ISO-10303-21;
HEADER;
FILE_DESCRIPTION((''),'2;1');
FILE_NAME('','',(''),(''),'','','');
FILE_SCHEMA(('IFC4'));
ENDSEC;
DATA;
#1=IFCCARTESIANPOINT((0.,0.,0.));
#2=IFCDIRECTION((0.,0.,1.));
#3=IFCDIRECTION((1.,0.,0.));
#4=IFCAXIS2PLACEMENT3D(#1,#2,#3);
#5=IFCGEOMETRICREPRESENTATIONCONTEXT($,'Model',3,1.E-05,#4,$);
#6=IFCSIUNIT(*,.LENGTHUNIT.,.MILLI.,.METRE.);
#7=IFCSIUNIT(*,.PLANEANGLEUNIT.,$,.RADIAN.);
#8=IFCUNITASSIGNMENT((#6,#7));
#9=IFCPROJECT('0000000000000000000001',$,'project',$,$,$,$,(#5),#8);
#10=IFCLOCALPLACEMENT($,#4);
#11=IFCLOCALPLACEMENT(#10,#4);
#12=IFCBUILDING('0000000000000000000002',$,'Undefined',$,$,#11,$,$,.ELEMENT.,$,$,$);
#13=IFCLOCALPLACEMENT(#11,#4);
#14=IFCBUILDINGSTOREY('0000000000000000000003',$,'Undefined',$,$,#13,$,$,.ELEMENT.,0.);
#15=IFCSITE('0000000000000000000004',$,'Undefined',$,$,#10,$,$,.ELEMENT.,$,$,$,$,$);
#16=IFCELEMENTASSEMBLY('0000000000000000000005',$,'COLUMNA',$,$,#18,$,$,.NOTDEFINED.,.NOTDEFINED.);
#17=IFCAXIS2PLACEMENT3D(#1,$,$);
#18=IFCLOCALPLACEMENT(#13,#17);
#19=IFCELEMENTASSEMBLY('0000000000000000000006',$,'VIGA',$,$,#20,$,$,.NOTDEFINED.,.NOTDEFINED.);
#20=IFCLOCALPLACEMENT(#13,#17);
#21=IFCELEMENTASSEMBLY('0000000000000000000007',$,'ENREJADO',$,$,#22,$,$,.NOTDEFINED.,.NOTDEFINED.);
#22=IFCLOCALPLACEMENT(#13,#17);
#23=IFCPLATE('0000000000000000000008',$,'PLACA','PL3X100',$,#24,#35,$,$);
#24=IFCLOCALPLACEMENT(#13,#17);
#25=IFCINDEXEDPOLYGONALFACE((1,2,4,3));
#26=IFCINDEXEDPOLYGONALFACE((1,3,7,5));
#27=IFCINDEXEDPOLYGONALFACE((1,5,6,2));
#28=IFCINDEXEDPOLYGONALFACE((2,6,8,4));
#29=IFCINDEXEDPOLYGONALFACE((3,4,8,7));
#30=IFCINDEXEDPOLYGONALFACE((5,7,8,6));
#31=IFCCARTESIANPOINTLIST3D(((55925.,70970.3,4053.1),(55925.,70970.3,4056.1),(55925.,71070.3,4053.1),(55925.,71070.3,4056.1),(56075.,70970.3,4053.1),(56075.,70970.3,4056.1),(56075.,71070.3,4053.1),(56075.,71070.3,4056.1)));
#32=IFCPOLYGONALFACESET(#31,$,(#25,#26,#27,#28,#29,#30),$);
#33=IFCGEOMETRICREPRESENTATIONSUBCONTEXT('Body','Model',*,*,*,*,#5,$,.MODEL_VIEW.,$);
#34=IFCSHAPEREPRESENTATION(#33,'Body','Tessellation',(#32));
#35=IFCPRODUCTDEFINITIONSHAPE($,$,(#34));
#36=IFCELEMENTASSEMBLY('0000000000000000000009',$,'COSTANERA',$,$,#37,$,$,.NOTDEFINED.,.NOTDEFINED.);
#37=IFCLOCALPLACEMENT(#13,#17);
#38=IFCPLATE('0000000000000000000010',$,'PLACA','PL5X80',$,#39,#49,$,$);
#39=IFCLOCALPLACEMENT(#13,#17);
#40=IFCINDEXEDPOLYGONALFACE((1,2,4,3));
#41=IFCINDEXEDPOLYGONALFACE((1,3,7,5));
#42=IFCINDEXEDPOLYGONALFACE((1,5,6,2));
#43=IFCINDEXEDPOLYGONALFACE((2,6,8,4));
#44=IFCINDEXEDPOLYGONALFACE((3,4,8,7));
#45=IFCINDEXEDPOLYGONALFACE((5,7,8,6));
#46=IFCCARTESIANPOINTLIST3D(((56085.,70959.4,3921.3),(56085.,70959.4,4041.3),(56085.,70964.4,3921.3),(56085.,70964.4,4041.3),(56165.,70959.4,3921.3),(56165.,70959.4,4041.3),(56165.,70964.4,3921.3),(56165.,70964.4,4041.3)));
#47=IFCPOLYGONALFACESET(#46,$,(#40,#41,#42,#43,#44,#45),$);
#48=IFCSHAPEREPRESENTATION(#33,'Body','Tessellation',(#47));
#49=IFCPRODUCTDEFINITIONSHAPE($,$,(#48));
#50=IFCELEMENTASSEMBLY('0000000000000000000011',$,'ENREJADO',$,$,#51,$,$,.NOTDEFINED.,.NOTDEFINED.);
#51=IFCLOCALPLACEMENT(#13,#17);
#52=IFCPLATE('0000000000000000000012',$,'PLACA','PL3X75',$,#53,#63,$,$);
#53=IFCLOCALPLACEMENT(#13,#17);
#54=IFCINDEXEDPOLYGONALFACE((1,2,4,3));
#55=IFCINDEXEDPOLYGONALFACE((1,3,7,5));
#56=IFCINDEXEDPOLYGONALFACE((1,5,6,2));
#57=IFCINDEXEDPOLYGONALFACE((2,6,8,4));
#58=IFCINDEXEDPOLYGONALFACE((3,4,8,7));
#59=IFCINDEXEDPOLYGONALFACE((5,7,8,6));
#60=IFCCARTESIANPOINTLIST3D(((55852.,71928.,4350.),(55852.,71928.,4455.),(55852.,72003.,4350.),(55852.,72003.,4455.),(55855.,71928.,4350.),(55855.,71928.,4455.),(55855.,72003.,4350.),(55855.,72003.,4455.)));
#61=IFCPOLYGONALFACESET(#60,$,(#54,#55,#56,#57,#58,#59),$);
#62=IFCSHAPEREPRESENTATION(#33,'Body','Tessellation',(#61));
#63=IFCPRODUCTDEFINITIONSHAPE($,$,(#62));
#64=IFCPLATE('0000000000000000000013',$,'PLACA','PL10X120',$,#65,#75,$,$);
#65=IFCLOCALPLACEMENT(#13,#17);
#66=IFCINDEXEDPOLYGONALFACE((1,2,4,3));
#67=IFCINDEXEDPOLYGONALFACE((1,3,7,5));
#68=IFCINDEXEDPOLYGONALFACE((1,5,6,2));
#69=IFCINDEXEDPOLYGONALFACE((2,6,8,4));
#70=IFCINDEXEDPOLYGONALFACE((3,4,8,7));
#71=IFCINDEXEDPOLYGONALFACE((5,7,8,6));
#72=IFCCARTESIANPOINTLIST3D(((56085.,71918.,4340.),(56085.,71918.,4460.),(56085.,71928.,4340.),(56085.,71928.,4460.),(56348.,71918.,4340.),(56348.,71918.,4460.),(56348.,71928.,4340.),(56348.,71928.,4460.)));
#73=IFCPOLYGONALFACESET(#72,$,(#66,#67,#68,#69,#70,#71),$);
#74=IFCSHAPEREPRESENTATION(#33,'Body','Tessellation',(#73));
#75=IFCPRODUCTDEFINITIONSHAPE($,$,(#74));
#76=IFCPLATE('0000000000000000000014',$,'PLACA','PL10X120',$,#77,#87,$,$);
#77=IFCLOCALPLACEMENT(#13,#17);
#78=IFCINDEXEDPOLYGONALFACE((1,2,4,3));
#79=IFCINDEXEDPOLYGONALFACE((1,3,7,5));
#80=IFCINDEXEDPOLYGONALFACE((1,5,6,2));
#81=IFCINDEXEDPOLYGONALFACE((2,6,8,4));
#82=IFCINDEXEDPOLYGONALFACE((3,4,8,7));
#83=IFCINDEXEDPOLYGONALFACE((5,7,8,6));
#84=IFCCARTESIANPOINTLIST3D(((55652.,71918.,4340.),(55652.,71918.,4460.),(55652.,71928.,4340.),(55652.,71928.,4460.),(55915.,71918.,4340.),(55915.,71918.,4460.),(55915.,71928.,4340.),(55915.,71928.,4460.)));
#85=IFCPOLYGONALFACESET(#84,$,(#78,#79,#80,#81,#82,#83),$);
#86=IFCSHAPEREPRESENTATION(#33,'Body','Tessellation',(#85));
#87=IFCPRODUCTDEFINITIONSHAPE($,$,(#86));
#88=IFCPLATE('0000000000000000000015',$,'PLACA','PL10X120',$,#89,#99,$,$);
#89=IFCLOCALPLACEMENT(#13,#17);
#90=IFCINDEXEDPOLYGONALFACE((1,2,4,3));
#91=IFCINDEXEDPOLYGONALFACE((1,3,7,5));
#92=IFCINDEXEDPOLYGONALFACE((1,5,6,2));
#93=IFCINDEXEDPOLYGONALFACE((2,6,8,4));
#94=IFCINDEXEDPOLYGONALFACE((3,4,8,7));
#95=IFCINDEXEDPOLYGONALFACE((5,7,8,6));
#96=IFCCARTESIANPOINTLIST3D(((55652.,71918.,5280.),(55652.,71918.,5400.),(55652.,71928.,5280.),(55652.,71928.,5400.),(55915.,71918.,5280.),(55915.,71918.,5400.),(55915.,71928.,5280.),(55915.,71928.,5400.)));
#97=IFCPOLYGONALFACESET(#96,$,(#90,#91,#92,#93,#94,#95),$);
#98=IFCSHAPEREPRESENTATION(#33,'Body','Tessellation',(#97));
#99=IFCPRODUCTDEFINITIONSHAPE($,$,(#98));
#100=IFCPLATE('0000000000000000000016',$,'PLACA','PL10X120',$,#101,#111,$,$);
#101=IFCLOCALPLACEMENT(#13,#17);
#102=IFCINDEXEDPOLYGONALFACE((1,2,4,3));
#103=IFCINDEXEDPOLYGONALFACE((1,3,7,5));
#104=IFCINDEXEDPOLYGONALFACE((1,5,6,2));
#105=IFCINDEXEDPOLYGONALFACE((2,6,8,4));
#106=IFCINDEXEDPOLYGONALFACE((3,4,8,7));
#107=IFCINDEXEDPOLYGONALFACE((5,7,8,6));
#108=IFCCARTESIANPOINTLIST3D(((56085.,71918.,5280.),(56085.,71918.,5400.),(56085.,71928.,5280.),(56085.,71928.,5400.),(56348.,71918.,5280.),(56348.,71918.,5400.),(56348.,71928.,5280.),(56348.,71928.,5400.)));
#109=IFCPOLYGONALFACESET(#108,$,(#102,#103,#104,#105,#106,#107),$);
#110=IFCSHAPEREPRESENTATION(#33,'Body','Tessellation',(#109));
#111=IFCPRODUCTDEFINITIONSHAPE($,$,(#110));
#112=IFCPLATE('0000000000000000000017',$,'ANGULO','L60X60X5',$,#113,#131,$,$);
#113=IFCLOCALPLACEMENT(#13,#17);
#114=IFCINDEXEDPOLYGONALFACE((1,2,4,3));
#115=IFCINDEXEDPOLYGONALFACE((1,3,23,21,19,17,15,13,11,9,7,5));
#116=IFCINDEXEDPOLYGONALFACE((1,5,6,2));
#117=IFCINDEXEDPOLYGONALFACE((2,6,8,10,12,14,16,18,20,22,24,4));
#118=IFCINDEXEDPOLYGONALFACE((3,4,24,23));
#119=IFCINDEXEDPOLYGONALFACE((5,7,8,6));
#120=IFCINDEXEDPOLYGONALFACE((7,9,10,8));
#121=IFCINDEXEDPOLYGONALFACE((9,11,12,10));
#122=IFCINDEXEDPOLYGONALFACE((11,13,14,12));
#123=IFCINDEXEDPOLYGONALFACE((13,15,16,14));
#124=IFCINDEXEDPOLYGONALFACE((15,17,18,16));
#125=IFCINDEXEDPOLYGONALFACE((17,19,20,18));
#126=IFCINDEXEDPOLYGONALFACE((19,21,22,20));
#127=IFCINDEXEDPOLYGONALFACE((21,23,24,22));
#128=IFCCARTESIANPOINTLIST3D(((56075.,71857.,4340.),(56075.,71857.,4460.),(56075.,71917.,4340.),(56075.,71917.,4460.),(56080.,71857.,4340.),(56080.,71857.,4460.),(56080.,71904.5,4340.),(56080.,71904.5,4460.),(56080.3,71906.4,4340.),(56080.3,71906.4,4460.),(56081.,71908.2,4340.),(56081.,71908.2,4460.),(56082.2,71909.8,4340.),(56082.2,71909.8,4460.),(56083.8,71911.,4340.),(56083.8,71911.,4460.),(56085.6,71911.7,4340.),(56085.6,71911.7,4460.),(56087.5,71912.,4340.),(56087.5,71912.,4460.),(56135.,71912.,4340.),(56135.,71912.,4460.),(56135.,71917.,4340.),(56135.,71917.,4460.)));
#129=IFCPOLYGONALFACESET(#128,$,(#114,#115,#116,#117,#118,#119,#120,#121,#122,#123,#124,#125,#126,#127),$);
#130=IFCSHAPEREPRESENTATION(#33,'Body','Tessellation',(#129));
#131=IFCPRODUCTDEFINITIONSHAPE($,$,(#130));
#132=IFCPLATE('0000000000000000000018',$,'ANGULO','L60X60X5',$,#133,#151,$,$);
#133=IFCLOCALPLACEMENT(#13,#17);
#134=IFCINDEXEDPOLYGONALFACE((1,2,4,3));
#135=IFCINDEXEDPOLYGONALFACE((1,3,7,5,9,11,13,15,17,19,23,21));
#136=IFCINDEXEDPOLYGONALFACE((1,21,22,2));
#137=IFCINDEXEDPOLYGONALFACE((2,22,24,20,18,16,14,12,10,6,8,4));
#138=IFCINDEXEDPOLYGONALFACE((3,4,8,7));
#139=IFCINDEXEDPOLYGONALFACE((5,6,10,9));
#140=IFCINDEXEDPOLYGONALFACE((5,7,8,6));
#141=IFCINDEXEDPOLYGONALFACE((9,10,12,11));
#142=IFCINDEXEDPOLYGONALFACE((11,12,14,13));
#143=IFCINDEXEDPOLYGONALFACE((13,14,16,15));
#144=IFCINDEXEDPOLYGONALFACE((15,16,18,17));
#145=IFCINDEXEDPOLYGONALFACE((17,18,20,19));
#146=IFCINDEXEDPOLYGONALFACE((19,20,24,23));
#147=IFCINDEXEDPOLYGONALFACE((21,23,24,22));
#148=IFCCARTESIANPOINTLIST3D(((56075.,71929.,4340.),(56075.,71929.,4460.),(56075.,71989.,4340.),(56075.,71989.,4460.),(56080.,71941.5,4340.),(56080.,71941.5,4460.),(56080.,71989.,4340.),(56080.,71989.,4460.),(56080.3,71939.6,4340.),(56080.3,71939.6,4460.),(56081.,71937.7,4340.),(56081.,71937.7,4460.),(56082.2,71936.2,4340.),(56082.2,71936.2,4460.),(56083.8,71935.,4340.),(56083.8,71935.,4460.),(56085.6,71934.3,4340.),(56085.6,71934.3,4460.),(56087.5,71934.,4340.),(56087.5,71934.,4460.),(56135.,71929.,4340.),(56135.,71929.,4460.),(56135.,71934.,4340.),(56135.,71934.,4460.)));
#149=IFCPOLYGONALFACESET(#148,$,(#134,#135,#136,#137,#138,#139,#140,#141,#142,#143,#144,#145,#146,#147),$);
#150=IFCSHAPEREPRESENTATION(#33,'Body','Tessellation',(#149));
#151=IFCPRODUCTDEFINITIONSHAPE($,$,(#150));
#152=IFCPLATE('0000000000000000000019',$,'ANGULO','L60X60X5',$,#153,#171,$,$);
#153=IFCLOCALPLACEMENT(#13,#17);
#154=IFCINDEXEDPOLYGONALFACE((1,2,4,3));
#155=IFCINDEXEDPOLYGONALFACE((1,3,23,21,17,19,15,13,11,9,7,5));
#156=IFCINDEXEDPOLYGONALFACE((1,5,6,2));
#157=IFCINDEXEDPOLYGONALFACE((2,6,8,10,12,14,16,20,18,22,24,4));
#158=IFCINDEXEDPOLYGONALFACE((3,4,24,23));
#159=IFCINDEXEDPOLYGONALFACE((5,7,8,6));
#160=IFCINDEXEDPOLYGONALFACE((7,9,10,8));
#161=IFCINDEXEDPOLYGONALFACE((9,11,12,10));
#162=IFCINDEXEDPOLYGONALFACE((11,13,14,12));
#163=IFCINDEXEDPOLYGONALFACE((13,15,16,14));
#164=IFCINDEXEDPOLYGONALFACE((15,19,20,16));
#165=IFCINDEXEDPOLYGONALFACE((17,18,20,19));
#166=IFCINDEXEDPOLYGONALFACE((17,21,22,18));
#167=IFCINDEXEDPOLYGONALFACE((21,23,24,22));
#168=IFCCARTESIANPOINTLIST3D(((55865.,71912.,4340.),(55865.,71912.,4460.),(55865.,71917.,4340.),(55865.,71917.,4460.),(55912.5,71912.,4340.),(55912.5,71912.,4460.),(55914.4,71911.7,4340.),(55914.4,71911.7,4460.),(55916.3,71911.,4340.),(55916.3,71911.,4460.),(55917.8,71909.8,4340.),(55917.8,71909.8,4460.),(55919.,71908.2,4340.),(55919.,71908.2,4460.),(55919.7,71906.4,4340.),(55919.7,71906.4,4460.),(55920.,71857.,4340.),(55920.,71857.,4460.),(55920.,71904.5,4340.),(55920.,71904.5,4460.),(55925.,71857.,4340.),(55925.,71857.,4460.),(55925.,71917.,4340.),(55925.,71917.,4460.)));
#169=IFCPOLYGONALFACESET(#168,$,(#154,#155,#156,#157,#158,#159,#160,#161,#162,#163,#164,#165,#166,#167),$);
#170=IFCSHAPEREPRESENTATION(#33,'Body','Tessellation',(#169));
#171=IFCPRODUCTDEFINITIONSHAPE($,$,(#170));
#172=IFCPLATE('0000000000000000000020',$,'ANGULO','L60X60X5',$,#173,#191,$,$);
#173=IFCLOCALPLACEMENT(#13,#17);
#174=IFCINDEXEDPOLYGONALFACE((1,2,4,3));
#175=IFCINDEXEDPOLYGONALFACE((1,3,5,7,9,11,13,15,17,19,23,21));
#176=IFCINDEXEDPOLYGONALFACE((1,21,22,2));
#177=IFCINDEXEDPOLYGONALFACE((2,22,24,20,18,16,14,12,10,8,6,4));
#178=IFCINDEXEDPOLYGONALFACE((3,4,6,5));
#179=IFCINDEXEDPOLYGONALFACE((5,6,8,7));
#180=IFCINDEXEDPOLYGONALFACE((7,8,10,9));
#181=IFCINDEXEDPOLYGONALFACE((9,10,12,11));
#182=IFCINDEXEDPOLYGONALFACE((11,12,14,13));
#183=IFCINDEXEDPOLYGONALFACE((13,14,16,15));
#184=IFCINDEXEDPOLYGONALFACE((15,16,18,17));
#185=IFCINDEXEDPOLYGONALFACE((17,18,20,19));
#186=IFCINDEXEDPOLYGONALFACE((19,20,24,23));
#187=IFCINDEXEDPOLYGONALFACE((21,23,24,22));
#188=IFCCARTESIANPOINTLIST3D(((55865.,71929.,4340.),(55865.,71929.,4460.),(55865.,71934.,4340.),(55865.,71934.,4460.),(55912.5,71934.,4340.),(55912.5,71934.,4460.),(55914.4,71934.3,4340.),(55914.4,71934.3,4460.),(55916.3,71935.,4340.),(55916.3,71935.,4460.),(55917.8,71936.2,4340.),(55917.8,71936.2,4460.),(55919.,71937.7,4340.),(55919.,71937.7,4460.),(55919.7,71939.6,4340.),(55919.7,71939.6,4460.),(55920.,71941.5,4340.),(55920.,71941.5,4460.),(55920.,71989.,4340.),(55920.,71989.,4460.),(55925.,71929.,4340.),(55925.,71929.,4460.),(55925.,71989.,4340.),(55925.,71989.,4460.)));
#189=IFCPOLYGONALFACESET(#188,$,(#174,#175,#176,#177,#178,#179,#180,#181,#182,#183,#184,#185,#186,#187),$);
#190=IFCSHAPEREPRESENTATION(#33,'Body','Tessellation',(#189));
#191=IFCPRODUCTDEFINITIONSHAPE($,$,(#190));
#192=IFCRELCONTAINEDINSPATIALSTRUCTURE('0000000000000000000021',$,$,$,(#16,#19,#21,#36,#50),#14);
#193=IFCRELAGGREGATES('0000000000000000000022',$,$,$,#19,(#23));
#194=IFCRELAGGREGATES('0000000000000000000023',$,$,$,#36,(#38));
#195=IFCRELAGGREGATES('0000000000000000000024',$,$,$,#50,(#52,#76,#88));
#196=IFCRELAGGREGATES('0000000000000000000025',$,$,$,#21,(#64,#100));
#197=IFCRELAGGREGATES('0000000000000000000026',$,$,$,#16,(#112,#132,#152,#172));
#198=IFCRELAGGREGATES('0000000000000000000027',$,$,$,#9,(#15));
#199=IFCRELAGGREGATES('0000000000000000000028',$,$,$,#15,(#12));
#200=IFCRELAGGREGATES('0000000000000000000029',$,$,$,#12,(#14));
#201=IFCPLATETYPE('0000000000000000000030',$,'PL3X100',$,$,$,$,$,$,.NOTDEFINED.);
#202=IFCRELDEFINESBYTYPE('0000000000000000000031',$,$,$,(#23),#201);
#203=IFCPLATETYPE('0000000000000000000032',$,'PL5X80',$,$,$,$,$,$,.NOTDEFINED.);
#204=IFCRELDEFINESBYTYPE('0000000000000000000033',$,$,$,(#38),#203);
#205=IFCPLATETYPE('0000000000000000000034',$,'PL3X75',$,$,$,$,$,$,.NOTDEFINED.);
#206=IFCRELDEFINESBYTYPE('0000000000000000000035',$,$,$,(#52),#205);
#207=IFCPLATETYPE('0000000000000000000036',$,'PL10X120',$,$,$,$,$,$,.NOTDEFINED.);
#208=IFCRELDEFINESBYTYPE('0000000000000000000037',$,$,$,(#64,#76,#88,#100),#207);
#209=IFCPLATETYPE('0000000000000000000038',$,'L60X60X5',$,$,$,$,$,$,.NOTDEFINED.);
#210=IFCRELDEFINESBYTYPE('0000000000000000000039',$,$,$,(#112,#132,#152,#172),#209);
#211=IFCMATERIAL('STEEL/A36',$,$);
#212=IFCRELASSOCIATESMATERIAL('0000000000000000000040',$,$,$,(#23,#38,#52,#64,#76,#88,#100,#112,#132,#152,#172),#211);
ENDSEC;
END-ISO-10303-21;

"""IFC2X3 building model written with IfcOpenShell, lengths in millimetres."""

from ifc_helpers import new_model, si_unit, frame, origin_with_axes, origin_2d_with_axis, place, context, subcontext, project, spatial, polyline, l_section, outline, extrude, material, type_object, element, aggregate, save


model = new_model("IFC2X3")

# Units and contexts
model_context = context("Model", 3, precision=1e-05, world=origin_with_axes())
body_context = subcontext(model_context, "Body", "Model", "MODEL_VIEW")
ifc_project = project(units=[si_unit("LENGTHUNIT", "METRE", prefix="MILLI"), si_unit("PLANEANGLEUNIT", "RADIAN")], contexts=[model_context])

# Site, building, storey
site_placement = place(None, origin_with_axes())
site = spatial("IfcSite", under=ifc_project, at=site_placement, Name="Undefined", CompositionType="ELEMENT")
building_placement = place(site_placement, origin_with_axes())
building = spatial("IfcBuilding", under=site, at=building_placement, Name="Undefined", CompositionType="ELEMENT")
storey_placement = place(building_placement, origin_with_axes())
storey = spatial("IfcBuildingStorey", under=building, at=storey_placement, Name="Undefined", CompositionType="ELEMENT", Elevation=0.0)

# Element assembly
assembly_1_placement = place(storey_placement, origin_with_axes())
assembly_1 = element("IfcElementAssembly", 1, at=assembly_1_placement, inside=storey, Name="COLUMNA", AssemblyPlace="NOTDEFINED", PredefinedType="NOTDEFINED")
ifc_material_1 = material(Name="STEEL/A36")

# Element assemblies
assembly_2_placement = place(storey_placement, origin_with_axes())
assembly_2 = element("IfcElementAssembly", 2, at=assembly_2_placement, inside=storey, Name="VIGA", AssemblyPlace="NOTDEFINED", PredefinedType="NOTDEFINED")
assembly_3_placement = place(storey_placement, origin_with_axes())
assembly_3 = element("IfcElementAssembly", 3, at=assembly_3_placement, inside=storey, Name="ENREJADO", AssemblyPlace="NOTDEFINED", PredefinedType="NOTDEFINED")

# Plate
plate_type_1 = type_object("IfcPlateType", Name="PL3X100", PredefinedType="NOTDEFINED")
plate_1_placement = place(assembly_2_placement, frame((56075.0, 71070.3, 4054.6), z_axis=(0.0, 0.0, -1.0), x_axis=(0.0, -1.0, 0.0)))
plate_1 = element("IfcPlate", 4, at=plate_1_placement, type_object=plate_type_1, material=ifc_material_1, Name="PLACA", Description="PL3X100", context=body_context, shape_type="SweptSolid", body=[
    extrude(outline(polyline([(0.0, 0.0), (100.0, 0.0), (100.0, 150.0), (0.0, 150.0), (0.0, 0.0)])), frame((0.0, 0.0, -1.5), z_axis=(0.0, 0.0, 1.0), x_axis=(1.0, 0.0, 0.0)), (0.0, 0.0, 1.0), 3.0),
])
aggregate(assembly_2, [plate_1])

# Element assemblies, plates
assembly_4_placement = place(storey_placement, origin_with_axes())
assembly_4 = element("IfcElementAssembly", 5, at=assembly_4_placement, inside=storey, Name="COSTANERA", AssemblyPlace="NOTDEFINED", PredefinedType="NOTDEFINED")
plate_type_2 = type_object("IfcPlateType", Name="PL5X80", PredefinedType="NOTDEFINED")
plate_2_placement = place(assembly_4_placement, frame((56085.0, 70961.9, 4041.3), z_axis=(0.0, 1.0, 0.0), x_axis=(1.0, 0.0, 0.0)))
plate_2 = element("IfcPlate", 6, at=plate_2_placement, type_object=plate_type_2, material=ifc_material_1, Name="PLACA", Description="PL5X80", context=body_context, shape_type="SweptSolid", body=[
    extrude(outline(polyline([(0.0, 0.0), (80.0, 0.0), (80.0, 120.0), (0.0, 120.0), (0.0, 0.0)])), frame((0.0, 0.0, -2.5), z_axis=(0.0, 0.0, 1.0), x_axis=(1.0, 0.0, 0.0)), (0.0, 0.0, 1.0), 5.0),
])
aggregate(assembly_4, [plate_2])
assembly_5_placement = place(storey_placement, origin_with_axes())
assembly_5 = element("IfcElementAssembly", 7, at=assembly_5_placement, inside=storey, Name="ENREJADO", AssemblyPlace="NOTDEFINED", PredefinedType="NOTDEFINED")
plate_type_3 = type_object("IfcPlateType", Name="PL3X75", PredefinedType="NOTDEFINED")
plate_3_placement = place(assembly_5_placement, frame((55853.5, 71928.0, 4455.0), z_axis=(-1.0, 0.0, 0.0), x_axis=(0.0, 1.0, 0.0)))
plate_3 = element("IfcPlate", 8, at=plate_3_placement, type_object=plate_type_3, material=ifc_material_1, Name="PLACA", Description="PL3X75", context=body_context, shape_type="SweptSolid", body=[
    extrude(outline(polyline([(0.0, 0.0), (75.0, 0.0), (75.0, 105.0), (0.0, 105.0), (0.0, 0.0)])), frame((0.0, 0.0, -1.5), z_axis=(0.0, 0.0, 1.0), x_axis=(1.0, 0.0, 0.0)), (0.0, 0.0, 1.0), 3.0),
])

# Plates
plate_type_4 = type_object("IfcPlateType", Name="PL10X120", PredefinedType="NOTDEFINED")
plate_4_placement = place(assembly_3_placement, frame((56085.0, 71923.0, 4400.0), z_axis=(0.0, 1.0, 0.0), x_axis=(1.0, 0.0, 0.0)))
plate_4 = element("IfcPlate", 9, at=plate_4_placement, type_object=plate_type_4, material=ifc_material_1, Name="PLACA", Description="PL10X120", context=body_context, shape_type="SweptSolid", body=[
    extrude(outline(polyline([(0.0, -60.0), (0.0, 60.0), (263.0, 60.0), (263.0, -60.0), (0.0, -60.0)])), frame((0.0, 0.0, -5.0), z_axis=(0.0, 0.0, 1.0), x_axis=(1.0, 0.0, 0.0)), (0.0, 0.0, 1.0), 10.0),
])
plate_5_placement = place(assembly_5_placement, frame((55915.0, 71923.0, 4400.0), z_axis=(0.0, 1.0, 0.0), x_axis=(-1.0, 0.0, 0.0)))
plate_5 = element("IfcPlate", 10, at=plate_5_placement, type_object=plate_type_4, material=ifc_material_1, Name="PLACA", Description="PL10X120", context=body_context, shape_type="SweptSolid", body=[
    extrude(outline(polyline([(0.0, -60.0), (0.0, 60.0), (263.0, 60.0), (263.0, -60.0), (0.0, -60.0)])), frame((0.0, 0.0, -5.0), z_axis=(0.0, 0.0, 1.0), x_axis=(1.0, 0.0, 0.0)), (0.0, 0.0, 1.0), 10.0),
])
plate_6_placement = place(assembly_5_placement, frame((55915.0, 71923.0, 5340.0), z_axis=(0.0, -1.0, 0.0), x_axis=(-1.0, 0.0, 0.0)))
plate_6 = element("IfcPlate", 11, at=plate_6_placement, type_object=plate_type_4, material=ifc_material_1, Name="PLACA", Description="PL10X120", context=body_context, shape_type="SweptSolid", body=[
    extrude(outline(polyline([(0.0, -60.0), (0.0, 60.0), (263.0, 60.0), (263.0, -60.0), (0.0, -60.0)])), frame((0.0, 0.0, -5.0), z_axis=(0.0, 0.0, 1.0), x_axis=(1.0, 0.0, 0.0)), (0.0, 0.0, 1.0), 10.0),
])
aggregate(assembly_5, [plate_3, plate_5, plate_6])
plate_7_placement = place(assembly_3_placement, frame((56085.0, 71923.0, 5340.0), z_axis=(0.0, 1.0, 0.0), x_axis=(1.0, 0.0, 0.0)))
plate_7 = element("IfcPlate", 12, at=plate_7_placement, type_object=plate_type_4, material=ifc_material_1, Name="PLACA", Description="PL10X120", context=body_context, shape_type="SweptSolid", body=[
    extrude(outline(polyline([(0.0, -60.0), (0.0, 60.0), (263.0, 60.0), (263.0, -60.0), (0.0, -60.0)])), frame((0.0, 0.0, -5.0), z_axis=(0.0, 0.0, 1.0), x_axis=(1.0, 0.0, 0.0)), (0.0, 0.0, 1.0), 10.0),
])
aggregate(assembly_3, [plate_4, plate_7])
plate_type_5 = type_object("IfcPlateType", Name="L60X60X5", PredefinedType="NOTDEFINED")
plate_8_placement = place(assembly_1_placement, frame((56105.0, 71887.0, 4340.0), z_axis=(0.0, -1.0, 0.0), x_axis=(0.0, 0.0, 1.0)))
plate_8 = element("IfcPlate", 13, at=plate_8_placement, type_object=plate_type_5, material=ifc_material_1, Name="ANGULO", Description="L60X60X5", context=body_context, shape_type="SweptSolid", body=[
    extrude(l_section(Depth=60.0, Width=60.0, Thickness=5.0, FilletRadius=7.5, at=origin_2d_with_axis()), frame((120.0, 0.0, 0.0), z_axis=(-1.0, 0.0, 0.0), x_axis=(0.0, -1.0, 0.0)), (0.0, 0.0, 1.0), 120.0),
])
plate_9_placement = place(assembly_1_placement, frame((56105.0, 71959.0, 4460.0), z_axis=(0.0, 1.0, 0.0), x_axis=(0.0, 0.0, -1.0)))
plate_9 = element("IfcPlate", 14, at=plate_9_placement, type_object=plate_type_5, material=ifc_material_1, Name="ANGULO", Description="L60X60X5", context=body_context, shape_type="SweptSolid", body=[
    extrude(l_section(Depth=60.0, Width=60.0, Thickness=5.0, FilletRadius=7.5, at=origin_2d_with_axis()), frame((120.0, 0.0, 0.0), z_axis=(-1.0, 0.0, 0.0), x_axis=(0.0, -1.0, 0.0)), (0.0, 0.0, 1.0), 120.0),
])
plate_10_placement = place(assembly_1_placement, frame((55895.0, 71887.0, 4460.0), z_axis=(0.0, -1.0, 0.0), x_axis=(0.0, 0.0, -1.0)))
plate_10 = element("IfcPlate", 15, at=plate_10_placement, type_object=plate_type_5, material=ifc_material_1, Name="ANGULO", Description="L60X60X5", context=body_context, shape_type="SweptSolid", body=[
    extrude(l_section(Depth=60.0, Width=60.0, Thickness=5.0, FilletRadius=7.5, at=origin_2d_with_axis()), frame((120.0, 0.0, 0.0), z_axis=(-1.0, 0.0, 0.0), x_axis=(0.0, -1.0, 0.0)), (0.0, 0.0, 1.0), 120.0),
])
plate_11_placement = place(assembly_1_placement, frame((55895.0, 71959.0, 4340.0), z_axis=(0.0, 1.0, 0.0), x_axis=(0.0, 0.0, 1.0)))
plate_11 = element("IfcPlate", 16, at=plate_11_placement, type_object=plate_type_5, material=ifc_material_1, Name="ANGULO", Description="L60X60X5", context=body_context, shape_type="SweptSolid", body=[
    extrude(l_section(Depth=60.0, Width=60.0, Thickness=5.0, FilletRadius=7.5, at=origin_2d_with_axis()), frame((120.0, 0.0, 0.0), z_axis=(-1.0, 0.0, 0.0), x_axis=(0.0, -1.0, 0.0)), (0.0, 0.0, 1.0), 120.0),
])

aggregate(assembly_1, [plate_8, plate_9, plate_10, plate_11])

save(model, "model.ifc")
